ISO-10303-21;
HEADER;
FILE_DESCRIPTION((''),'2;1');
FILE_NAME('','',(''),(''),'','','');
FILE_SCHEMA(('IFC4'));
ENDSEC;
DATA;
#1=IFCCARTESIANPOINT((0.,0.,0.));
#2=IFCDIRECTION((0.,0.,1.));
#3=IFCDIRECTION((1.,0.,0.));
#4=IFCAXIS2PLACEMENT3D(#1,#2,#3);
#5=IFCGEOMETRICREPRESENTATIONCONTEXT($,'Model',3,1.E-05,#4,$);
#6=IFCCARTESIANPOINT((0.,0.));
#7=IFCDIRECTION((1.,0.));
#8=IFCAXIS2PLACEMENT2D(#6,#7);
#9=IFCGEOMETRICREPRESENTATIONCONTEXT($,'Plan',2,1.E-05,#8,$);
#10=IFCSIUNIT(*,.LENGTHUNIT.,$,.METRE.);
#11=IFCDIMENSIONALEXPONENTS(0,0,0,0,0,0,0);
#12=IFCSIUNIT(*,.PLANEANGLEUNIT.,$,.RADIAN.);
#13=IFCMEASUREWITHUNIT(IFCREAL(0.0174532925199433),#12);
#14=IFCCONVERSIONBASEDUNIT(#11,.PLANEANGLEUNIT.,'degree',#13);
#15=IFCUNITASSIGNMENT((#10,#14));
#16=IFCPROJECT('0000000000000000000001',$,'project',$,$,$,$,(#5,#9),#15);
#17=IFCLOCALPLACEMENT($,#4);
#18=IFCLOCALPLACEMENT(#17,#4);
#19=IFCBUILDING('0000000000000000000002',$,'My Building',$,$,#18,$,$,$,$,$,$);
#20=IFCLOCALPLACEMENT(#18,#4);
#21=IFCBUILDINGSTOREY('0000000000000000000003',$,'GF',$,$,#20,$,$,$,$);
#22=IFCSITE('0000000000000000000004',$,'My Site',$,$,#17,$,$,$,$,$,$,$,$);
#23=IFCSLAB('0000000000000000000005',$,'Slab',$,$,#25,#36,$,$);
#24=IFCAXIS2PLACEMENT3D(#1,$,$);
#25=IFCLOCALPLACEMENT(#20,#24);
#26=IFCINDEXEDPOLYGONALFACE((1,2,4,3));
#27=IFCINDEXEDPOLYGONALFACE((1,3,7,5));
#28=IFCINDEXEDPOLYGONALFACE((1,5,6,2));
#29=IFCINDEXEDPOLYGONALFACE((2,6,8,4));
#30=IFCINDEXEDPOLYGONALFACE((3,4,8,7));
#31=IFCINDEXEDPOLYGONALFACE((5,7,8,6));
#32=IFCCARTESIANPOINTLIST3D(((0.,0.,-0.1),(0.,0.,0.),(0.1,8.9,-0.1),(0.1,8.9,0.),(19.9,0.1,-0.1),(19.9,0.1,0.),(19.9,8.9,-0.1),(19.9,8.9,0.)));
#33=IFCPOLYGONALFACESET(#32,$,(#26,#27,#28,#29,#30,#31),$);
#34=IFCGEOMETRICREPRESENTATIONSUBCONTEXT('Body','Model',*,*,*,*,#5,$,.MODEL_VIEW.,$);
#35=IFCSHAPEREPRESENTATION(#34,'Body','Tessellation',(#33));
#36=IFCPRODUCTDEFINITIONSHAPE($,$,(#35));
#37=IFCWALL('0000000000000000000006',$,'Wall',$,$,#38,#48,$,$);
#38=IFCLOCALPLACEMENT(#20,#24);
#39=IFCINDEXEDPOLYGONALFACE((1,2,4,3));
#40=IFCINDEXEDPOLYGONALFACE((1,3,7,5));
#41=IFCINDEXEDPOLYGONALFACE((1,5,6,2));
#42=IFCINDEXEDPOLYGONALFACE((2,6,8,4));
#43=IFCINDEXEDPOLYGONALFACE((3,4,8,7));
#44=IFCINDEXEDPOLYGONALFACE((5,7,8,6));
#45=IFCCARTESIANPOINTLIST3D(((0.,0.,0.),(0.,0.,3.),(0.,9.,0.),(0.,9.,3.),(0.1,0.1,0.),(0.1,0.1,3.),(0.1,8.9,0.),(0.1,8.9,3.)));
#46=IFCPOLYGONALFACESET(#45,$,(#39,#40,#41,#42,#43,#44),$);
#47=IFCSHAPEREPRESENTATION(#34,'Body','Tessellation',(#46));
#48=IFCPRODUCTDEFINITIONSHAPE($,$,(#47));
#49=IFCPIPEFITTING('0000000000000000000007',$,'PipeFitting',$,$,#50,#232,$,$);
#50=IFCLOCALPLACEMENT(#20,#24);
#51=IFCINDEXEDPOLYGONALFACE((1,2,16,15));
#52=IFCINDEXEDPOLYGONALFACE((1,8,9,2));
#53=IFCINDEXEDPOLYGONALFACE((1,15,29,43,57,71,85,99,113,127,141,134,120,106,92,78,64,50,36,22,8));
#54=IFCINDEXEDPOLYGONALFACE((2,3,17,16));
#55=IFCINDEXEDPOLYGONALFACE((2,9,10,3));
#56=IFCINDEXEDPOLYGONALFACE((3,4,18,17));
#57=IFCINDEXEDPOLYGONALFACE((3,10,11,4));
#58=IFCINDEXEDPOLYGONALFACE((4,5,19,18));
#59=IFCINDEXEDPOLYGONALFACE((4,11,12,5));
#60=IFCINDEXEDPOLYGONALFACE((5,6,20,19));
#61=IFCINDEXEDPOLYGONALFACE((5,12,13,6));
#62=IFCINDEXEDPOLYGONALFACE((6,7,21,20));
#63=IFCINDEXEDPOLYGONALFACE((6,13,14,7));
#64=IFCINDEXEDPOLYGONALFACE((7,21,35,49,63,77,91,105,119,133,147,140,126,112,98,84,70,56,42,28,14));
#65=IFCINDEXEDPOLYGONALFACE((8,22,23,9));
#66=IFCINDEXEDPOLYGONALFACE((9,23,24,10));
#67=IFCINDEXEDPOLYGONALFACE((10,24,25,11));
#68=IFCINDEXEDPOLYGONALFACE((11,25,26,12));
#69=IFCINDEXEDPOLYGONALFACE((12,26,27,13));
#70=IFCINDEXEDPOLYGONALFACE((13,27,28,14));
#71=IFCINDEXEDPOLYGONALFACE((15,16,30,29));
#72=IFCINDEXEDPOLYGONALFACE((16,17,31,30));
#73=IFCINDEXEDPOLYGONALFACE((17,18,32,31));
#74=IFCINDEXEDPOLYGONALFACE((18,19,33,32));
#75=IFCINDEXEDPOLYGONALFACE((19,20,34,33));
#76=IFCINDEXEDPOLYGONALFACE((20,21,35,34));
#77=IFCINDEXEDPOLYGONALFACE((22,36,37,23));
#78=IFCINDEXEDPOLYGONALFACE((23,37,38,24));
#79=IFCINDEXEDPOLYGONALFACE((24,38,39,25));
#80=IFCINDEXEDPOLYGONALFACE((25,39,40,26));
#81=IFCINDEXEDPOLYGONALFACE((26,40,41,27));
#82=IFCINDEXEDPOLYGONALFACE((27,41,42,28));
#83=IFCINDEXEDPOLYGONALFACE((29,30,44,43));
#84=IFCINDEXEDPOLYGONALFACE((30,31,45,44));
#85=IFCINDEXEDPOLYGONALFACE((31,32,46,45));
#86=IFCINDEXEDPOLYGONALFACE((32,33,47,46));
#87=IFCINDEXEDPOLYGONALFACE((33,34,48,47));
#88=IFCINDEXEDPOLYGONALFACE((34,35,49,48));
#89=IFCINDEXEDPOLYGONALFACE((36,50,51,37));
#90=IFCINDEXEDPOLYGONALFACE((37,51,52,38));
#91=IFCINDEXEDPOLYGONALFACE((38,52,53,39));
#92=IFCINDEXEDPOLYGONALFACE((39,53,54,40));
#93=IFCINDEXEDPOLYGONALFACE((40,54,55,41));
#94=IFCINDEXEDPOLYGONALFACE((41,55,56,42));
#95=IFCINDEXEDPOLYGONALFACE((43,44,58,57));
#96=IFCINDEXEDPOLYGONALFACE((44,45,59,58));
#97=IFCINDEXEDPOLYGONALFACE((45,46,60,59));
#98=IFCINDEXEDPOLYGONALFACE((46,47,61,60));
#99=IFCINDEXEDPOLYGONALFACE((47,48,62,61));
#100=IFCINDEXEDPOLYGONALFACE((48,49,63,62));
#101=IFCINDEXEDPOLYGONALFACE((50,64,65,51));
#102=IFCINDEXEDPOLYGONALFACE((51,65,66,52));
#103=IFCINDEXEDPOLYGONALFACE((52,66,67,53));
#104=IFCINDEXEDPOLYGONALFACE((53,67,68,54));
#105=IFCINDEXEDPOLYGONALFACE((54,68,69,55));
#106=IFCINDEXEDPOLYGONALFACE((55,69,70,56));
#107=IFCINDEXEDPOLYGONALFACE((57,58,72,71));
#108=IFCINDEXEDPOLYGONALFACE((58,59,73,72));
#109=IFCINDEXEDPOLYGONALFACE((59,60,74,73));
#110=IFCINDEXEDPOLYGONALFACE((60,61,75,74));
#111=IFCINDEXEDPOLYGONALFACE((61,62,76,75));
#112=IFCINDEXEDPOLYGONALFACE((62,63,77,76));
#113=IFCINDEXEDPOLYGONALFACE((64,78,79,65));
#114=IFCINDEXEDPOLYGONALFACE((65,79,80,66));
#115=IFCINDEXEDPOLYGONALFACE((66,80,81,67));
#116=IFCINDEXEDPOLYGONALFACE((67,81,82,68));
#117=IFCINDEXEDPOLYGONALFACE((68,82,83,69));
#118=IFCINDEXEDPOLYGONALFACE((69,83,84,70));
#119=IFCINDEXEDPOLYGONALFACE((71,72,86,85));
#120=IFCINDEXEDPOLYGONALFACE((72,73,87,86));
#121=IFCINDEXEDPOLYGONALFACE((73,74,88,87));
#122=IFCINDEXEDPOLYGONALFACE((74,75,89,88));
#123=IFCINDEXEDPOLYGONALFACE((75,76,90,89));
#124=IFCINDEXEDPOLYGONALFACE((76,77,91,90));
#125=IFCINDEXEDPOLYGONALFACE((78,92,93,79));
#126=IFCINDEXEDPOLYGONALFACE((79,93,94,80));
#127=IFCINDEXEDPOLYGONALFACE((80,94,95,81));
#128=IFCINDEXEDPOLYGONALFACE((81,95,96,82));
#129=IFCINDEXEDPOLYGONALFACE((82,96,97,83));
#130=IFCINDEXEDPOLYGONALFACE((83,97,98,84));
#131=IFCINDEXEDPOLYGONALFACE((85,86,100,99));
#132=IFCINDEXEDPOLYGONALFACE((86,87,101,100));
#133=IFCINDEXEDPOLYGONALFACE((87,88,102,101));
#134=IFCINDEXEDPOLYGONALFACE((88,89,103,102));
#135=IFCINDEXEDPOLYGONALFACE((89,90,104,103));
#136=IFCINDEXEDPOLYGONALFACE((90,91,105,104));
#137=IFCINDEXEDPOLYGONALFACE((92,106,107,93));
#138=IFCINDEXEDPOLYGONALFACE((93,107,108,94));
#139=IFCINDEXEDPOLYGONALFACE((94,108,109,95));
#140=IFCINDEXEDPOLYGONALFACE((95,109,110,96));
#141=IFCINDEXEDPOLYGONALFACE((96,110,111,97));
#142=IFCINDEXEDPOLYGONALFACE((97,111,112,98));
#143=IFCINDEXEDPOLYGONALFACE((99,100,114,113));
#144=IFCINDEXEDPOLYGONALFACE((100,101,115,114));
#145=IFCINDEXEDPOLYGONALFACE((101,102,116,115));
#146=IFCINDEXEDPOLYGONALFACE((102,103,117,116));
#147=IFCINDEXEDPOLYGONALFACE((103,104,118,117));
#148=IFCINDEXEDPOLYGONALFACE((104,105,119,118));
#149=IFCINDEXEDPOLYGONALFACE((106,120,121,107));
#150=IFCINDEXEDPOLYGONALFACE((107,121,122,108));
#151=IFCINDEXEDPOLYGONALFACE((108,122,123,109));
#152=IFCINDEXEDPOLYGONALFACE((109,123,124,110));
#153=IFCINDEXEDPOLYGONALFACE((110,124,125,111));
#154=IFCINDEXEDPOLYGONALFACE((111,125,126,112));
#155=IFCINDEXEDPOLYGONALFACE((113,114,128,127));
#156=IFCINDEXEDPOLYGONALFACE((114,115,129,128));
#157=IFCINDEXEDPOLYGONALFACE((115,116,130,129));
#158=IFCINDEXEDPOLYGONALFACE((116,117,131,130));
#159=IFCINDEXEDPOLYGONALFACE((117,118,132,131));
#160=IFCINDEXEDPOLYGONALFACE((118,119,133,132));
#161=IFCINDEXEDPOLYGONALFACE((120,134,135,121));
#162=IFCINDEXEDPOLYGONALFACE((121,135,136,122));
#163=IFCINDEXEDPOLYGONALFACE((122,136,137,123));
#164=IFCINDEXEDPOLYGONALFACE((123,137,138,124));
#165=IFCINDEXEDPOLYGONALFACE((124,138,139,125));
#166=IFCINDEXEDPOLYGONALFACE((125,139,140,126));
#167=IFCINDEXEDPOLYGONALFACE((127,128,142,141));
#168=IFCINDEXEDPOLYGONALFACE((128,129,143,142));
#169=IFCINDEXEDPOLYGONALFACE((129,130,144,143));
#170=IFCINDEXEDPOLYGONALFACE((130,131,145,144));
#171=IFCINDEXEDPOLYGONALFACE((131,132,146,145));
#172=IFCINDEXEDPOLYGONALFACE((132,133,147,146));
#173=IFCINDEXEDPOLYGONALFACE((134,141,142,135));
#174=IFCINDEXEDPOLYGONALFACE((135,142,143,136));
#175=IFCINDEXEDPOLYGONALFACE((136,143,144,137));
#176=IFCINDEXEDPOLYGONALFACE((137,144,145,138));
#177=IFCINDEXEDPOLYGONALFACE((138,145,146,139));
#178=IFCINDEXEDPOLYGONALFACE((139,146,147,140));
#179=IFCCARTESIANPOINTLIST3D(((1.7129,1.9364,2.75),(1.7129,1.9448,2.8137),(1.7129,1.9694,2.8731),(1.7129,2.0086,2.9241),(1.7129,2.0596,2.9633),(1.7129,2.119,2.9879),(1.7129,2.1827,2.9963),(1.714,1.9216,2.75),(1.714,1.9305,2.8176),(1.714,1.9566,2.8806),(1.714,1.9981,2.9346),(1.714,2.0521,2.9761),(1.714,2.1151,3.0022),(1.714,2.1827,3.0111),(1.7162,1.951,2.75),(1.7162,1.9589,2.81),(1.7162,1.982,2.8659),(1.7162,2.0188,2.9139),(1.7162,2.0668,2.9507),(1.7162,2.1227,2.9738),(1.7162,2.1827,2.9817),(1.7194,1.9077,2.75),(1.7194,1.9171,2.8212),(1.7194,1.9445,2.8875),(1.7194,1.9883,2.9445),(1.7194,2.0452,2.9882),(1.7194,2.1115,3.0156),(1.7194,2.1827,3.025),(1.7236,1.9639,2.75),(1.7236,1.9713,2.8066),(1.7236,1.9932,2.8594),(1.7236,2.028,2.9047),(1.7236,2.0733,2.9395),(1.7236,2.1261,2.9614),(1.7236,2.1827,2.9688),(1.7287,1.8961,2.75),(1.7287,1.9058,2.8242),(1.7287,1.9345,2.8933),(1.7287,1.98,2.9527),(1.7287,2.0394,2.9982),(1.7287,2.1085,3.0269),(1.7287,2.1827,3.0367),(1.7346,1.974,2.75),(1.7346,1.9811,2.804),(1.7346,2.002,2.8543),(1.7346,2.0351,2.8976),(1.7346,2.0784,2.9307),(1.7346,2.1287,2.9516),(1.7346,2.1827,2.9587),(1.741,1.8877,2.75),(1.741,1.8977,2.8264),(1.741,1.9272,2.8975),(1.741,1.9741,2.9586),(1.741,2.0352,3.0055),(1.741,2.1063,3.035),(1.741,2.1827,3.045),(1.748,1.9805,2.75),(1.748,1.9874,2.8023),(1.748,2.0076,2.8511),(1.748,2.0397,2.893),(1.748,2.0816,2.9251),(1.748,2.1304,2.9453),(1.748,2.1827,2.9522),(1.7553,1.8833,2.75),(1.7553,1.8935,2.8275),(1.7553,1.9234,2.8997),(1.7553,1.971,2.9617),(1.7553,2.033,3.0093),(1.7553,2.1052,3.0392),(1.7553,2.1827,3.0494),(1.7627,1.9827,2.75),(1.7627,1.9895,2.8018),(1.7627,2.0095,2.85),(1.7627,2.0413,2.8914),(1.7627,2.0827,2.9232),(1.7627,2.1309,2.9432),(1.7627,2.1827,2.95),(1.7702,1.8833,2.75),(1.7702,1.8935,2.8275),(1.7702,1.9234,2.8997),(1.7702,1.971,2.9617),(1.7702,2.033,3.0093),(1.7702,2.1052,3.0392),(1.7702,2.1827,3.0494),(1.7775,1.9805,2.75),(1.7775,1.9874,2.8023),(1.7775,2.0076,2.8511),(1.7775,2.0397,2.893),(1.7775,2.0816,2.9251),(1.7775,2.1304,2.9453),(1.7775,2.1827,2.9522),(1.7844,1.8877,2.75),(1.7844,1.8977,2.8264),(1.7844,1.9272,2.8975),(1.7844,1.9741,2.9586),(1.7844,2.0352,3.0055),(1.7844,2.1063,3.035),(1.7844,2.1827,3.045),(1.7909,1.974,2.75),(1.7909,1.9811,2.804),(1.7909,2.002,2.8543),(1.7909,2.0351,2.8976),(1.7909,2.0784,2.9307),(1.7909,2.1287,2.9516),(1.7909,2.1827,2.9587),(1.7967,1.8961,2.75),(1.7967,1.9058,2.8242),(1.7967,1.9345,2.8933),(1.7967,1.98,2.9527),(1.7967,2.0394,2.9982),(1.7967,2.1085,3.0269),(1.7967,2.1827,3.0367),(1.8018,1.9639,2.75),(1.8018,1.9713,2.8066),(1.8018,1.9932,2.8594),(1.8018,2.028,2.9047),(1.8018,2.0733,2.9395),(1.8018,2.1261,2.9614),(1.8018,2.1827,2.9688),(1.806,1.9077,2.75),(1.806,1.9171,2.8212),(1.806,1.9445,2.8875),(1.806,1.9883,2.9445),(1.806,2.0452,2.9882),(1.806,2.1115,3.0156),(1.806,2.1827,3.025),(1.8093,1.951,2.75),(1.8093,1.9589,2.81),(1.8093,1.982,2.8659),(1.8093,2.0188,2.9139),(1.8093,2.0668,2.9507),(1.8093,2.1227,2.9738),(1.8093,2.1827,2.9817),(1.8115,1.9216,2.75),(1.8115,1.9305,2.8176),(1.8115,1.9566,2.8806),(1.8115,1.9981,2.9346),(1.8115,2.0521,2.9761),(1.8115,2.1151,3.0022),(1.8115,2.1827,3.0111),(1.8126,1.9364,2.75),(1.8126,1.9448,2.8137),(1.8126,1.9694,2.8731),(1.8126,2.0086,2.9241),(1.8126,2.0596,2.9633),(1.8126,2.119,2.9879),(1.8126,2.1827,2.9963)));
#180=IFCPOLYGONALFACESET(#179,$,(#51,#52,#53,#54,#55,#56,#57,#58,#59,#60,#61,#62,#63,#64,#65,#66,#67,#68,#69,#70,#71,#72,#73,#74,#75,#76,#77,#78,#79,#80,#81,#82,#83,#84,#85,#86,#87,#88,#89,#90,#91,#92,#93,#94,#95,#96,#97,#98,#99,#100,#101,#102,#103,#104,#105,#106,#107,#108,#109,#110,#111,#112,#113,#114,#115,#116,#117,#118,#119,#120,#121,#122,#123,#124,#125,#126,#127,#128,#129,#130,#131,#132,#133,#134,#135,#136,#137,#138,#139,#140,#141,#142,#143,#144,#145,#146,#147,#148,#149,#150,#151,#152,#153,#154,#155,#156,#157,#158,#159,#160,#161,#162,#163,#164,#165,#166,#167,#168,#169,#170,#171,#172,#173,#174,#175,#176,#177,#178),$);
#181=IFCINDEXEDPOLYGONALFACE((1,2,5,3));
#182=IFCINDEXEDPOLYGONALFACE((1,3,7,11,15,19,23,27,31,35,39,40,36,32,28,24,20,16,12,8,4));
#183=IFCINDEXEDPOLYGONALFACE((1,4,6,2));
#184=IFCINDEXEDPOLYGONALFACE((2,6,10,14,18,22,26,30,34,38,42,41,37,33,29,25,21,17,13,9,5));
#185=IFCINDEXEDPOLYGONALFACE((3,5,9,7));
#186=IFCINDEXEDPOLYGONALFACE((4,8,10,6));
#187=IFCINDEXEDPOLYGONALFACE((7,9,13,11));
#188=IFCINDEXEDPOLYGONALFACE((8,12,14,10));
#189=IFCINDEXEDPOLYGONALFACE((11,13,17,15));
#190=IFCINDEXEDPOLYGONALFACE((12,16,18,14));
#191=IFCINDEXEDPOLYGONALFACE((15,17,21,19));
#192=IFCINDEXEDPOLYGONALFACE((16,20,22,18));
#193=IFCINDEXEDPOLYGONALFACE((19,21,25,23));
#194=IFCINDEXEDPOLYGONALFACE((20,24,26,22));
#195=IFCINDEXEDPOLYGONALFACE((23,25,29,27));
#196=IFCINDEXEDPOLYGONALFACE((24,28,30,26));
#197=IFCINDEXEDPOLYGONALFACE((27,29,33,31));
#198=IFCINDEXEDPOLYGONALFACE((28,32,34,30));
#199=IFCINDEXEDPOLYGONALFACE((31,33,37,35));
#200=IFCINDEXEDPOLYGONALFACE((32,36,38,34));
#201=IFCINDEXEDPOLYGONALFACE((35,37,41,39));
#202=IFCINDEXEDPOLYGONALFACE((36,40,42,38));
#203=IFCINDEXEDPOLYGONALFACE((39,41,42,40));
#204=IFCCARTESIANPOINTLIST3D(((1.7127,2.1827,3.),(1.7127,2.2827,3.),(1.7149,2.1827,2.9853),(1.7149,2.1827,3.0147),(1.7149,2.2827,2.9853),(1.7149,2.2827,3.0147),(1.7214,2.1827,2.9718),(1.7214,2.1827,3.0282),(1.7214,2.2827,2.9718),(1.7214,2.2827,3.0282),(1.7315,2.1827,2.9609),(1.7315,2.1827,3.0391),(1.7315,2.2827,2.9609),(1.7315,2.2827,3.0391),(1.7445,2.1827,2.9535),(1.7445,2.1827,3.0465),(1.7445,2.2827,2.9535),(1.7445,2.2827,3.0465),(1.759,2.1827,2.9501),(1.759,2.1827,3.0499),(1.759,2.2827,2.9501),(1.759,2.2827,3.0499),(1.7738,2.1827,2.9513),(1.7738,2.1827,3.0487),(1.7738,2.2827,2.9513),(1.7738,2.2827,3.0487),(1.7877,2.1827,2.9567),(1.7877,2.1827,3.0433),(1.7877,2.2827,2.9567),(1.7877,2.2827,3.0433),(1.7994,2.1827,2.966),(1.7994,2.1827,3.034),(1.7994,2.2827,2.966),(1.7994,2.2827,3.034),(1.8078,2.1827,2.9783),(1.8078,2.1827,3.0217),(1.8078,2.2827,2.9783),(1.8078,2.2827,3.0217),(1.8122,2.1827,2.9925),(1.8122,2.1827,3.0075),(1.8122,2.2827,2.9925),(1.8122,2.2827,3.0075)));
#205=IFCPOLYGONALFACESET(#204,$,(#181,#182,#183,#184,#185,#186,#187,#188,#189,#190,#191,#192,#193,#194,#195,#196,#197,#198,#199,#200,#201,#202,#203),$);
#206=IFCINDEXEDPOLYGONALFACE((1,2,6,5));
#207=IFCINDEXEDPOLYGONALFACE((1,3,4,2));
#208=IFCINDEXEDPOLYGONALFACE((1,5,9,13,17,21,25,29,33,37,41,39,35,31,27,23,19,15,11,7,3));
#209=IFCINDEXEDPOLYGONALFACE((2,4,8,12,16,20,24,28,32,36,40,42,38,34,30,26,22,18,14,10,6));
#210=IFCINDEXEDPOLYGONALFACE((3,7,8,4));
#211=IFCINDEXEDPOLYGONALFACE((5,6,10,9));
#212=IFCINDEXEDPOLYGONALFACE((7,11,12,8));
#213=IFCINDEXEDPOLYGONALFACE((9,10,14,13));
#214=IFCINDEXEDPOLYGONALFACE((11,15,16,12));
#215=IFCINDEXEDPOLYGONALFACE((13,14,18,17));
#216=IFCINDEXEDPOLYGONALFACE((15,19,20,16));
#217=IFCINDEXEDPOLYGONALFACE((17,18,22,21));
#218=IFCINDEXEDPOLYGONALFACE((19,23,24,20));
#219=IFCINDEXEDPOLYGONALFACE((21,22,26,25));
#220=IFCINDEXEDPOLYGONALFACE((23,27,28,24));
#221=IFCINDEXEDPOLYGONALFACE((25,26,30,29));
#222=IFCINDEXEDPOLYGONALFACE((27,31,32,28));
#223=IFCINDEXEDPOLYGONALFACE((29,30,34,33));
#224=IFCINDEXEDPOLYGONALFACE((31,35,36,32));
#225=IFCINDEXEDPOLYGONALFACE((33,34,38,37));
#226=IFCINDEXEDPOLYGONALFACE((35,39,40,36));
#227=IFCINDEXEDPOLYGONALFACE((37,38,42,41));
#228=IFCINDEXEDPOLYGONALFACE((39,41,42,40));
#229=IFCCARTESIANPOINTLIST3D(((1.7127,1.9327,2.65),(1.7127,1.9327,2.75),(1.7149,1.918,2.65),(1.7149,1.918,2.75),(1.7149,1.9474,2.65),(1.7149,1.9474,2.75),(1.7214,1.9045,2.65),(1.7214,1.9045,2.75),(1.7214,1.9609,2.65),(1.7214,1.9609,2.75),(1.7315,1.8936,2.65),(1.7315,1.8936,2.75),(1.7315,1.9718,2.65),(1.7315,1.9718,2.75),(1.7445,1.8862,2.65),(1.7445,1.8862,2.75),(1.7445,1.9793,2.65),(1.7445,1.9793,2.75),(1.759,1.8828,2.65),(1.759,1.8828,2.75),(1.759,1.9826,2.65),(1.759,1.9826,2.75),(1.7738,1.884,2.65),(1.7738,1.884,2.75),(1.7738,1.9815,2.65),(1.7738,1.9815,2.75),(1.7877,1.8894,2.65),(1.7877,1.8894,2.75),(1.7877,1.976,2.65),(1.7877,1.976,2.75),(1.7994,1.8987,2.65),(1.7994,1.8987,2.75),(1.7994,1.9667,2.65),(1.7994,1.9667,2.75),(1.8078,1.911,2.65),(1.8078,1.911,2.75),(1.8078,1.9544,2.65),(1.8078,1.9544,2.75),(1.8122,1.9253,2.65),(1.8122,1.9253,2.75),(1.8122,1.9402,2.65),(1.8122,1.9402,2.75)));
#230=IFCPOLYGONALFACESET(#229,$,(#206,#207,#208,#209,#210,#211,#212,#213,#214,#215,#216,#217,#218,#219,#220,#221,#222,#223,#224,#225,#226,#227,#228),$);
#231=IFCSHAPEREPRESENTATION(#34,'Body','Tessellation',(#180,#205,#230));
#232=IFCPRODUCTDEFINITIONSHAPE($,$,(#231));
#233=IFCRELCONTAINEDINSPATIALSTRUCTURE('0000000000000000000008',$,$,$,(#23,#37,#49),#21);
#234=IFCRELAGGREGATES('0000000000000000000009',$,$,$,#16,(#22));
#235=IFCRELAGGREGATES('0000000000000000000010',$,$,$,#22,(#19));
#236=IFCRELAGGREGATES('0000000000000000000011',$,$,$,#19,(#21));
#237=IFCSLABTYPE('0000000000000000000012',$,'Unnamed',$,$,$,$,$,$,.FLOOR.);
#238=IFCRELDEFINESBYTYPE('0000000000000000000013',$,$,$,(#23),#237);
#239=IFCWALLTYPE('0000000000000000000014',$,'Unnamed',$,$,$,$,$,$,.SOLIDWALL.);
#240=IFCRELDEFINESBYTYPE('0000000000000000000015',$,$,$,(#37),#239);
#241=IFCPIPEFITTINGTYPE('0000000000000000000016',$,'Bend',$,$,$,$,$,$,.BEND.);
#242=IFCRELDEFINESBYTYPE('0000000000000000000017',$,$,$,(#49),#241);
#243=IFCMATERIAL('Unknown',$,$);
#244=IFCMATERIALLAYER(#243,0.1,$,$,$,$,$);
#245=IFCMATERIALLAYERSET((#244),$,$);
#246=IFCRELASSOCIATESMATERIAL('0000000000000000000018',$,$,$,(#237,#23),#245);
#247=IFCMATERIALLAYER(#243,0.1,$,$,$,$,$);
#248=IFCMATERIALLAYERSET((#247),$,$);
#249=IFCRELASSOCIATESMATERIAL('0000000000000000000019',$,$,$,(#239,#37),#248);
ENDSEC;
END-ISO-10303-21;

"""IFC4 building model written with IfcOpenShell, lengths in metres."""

from ifc_helpers import new_model, entity, si_unit, converted_unit, frame, origin_with_axes, origin_2d_with_axis, place, context, subcontext, project, spatial, line, indexed_curve, circle, outline, extrude, source, transform, mapped, material, layer, layer_set, layer_usage, type_object, type_shapes, element, save


model = new_model("IFC4")

# Units and contexts
model_context = context("Model", 3, precision=1e-05, world=origin_with_axes())
plan_context = context("Plan", 2, precision=1e-05, world=origin_2d_with_axis())
body_context_1 = subcontext(model_context, "Body", "Model", "MODEL_VIEW")
ifc_project = project(units=[si_unit("LENGTHUNIT", "METRE"), converted_unit("PLANEANGLEUNIT", "degree", entity("IfcReal", 0.0174532925199433), si_unit("PLANEANGLEUNIT", "RADIAN"), dimensions=[0, 0, 0, 0, 0, 0, 0])], contexts=[model_context, plan_context])

# Site, building, storey
site_placement = place(None, origin_with_axes())
site = spatial("IfcSite", under=ifc_project, at=site_placement, Name="My Site")
building_placement = place(site_placement, origin_with_axes())
building = spatial("IfcBuilding", under=site, at=building_placement, Name="My Building")
storey_placement = place(building_placement, origin_with_axes())
storey = spatial("IfcBuildingStorey", under=building, at=storey_placement, Name="GF")

# Slab
ifc_material = material(Name="Unknown")
ifc_layer_1 = layer(ifc_material, 0.1)
ifc_layer_set_1 = layer_set([ifc_layer_1])
ifc_layer_usage_1 = layer_usage(ifc_layer_set_1, "AXIS3", "POSITIVE", -0.1)
slab_type = type_object("IfcSlabType", Name="Unnamed", PredefinedType="FLOOR", material=ifc_layer_set_1)
slab_placement = place(storey_placement, frame((0.1, 8.9, 0.0), z_axis=(0.0, 0.0, 1.0), x_axis=(1.0, 0.0, 0.0)))
element("IfcSlab", 1, at=slab_placement, inside=storey, type_object=slab_type, material=ifc_layer_usage_1, Name="Slab", context=body_context_1, shape_type="SweptSolid", body=[
    extrude(outline(indexed_curve([(0.0, 0.0), (19.8, 0.0), (19.8, -8.8), (-0.1, -8.9), (0.0, 0.0)])), frame((0.0, 0.0, -0.1), z_axis=(0.0, 0.0, 1.0), x_axis=(1.0, 0.0, 0.0)), (0.0, 0.0, 1.0), 0.1),
])

# Shared definitions
ifc_layer_2 = layer(ifc_material, 0.1)
ifc_layer_set_2 = layer_set([ifc_layer_2])
wall_type = type_object("IfcWallType", Name="Unnamed", PredefinedType="SOLIDWALL", material=ifc_layer_set_2)

# Wall
ifc_layer_usage_2 = layer_usage(ifc_layer_set_2, "AXIS2", "POSITIVE", 0.0)
wall_1_placement = place(storey_placement, frame((0.0, 9.0, 0.0), z_axis=(0.0, 0.0, 1.0), x_axis=(0.0, -1.0, 0.0)))
element("IfcWall", 2, at=wall_1_placement, inside=storey, type_object=wall_type, material=ifc_layer_usage_2, Name="Wall", context=body_context_1, shape_type="SweptSolid", body=[
    extrude(outline(indexed_curve([(0.0, 0.0), (0.1, 0.1), (8.9, 0.1), (9.0, 0.0)], segments=[line(1, 2, 3, 4, 1)])), origin_with_axes(), (0.0, 0.0, 1.0), 3.0),
])

# Pipe fitting, opening
pipe_fitting_type = type_object("IfcPipeFittingType", Name="Bend", PredefinedType="BEND")
shared_shape_1 = source(origin_with_axes(), body_context_1, "Body", "SolidModel", [
    entity("IfcSweptDiskSolid", entity("IfcIndexedPolyCurve", entity("IfcCartesianPointList3D", [[0.0, 0.0, -0.1], [0.0, -0.0732, -0.2768], [0.0, -0.25, -0.35]]), [entity("IfcArcIndex", [1, 2, 3])]), 0.05),
    extrude(circle(Radius=0.05), origin_with_axes(), (0.0, 0.0, -1.0), 0.1),
    extrude(circle(Radius=0.05), frame((0.0, -0.25, -0.35), z_axis=(0.0, -1.0, 0.0), x_axis=(1.0, 0.0, 0.0)), (0.0, 0.0, 1.0), 0.1),
])
type_shapes(pipe_fitting_type, [shared_shape_1])
pipe_fitting_placement = place(storey_placement, frame((1.7627, 2.2827, 3.0), z_axis=(0.0, 1.0, 0.0), x_axis=(-1.0, 0.0, 0.0)))
pipe_fitting = element("IfcPipeFitting", 3, at=pipe_fitting_placement, inside=storey, type_object=pipe_fitting_type, Name="PipeFitting", context=body_context_1, shape_type="MappedRepresentation", body=[
    mapped(shared_shape_1, transform((0.0, 0.0, 0.0), x_axis=(1.0, 0.0, 0.0), y_axis=(0.0, 1.0, 0.0), z_axis=(0.0, 0.0, 1.0), scale=1.0)),
])
opening_1_placement = place(pipe_fitting_placement, frame((1.7627, -3.0, -2.2827), z_axis=(0.0, 1.0, 0.0), x_axis=(-1.0, 0.0, 0.0)))
element("IfcOpeningElement", 4, at=opening_1_placement, cuts=pipe_fitting, PredefinedType="OPENING", context=body_context_1, shape_type="SweptSolid", body=[
    extrude(outline(indexed_curve([(0.0, 0.0), (0.5, 0.0), (0.5, 0.5), (0.0, 0.5)], segments=[line(1, 2, 3, 4, 1)])), origin_with_axes(), (0.0, 0.0, 1.0), 0.5),
])

save(model, "model.ifc")
